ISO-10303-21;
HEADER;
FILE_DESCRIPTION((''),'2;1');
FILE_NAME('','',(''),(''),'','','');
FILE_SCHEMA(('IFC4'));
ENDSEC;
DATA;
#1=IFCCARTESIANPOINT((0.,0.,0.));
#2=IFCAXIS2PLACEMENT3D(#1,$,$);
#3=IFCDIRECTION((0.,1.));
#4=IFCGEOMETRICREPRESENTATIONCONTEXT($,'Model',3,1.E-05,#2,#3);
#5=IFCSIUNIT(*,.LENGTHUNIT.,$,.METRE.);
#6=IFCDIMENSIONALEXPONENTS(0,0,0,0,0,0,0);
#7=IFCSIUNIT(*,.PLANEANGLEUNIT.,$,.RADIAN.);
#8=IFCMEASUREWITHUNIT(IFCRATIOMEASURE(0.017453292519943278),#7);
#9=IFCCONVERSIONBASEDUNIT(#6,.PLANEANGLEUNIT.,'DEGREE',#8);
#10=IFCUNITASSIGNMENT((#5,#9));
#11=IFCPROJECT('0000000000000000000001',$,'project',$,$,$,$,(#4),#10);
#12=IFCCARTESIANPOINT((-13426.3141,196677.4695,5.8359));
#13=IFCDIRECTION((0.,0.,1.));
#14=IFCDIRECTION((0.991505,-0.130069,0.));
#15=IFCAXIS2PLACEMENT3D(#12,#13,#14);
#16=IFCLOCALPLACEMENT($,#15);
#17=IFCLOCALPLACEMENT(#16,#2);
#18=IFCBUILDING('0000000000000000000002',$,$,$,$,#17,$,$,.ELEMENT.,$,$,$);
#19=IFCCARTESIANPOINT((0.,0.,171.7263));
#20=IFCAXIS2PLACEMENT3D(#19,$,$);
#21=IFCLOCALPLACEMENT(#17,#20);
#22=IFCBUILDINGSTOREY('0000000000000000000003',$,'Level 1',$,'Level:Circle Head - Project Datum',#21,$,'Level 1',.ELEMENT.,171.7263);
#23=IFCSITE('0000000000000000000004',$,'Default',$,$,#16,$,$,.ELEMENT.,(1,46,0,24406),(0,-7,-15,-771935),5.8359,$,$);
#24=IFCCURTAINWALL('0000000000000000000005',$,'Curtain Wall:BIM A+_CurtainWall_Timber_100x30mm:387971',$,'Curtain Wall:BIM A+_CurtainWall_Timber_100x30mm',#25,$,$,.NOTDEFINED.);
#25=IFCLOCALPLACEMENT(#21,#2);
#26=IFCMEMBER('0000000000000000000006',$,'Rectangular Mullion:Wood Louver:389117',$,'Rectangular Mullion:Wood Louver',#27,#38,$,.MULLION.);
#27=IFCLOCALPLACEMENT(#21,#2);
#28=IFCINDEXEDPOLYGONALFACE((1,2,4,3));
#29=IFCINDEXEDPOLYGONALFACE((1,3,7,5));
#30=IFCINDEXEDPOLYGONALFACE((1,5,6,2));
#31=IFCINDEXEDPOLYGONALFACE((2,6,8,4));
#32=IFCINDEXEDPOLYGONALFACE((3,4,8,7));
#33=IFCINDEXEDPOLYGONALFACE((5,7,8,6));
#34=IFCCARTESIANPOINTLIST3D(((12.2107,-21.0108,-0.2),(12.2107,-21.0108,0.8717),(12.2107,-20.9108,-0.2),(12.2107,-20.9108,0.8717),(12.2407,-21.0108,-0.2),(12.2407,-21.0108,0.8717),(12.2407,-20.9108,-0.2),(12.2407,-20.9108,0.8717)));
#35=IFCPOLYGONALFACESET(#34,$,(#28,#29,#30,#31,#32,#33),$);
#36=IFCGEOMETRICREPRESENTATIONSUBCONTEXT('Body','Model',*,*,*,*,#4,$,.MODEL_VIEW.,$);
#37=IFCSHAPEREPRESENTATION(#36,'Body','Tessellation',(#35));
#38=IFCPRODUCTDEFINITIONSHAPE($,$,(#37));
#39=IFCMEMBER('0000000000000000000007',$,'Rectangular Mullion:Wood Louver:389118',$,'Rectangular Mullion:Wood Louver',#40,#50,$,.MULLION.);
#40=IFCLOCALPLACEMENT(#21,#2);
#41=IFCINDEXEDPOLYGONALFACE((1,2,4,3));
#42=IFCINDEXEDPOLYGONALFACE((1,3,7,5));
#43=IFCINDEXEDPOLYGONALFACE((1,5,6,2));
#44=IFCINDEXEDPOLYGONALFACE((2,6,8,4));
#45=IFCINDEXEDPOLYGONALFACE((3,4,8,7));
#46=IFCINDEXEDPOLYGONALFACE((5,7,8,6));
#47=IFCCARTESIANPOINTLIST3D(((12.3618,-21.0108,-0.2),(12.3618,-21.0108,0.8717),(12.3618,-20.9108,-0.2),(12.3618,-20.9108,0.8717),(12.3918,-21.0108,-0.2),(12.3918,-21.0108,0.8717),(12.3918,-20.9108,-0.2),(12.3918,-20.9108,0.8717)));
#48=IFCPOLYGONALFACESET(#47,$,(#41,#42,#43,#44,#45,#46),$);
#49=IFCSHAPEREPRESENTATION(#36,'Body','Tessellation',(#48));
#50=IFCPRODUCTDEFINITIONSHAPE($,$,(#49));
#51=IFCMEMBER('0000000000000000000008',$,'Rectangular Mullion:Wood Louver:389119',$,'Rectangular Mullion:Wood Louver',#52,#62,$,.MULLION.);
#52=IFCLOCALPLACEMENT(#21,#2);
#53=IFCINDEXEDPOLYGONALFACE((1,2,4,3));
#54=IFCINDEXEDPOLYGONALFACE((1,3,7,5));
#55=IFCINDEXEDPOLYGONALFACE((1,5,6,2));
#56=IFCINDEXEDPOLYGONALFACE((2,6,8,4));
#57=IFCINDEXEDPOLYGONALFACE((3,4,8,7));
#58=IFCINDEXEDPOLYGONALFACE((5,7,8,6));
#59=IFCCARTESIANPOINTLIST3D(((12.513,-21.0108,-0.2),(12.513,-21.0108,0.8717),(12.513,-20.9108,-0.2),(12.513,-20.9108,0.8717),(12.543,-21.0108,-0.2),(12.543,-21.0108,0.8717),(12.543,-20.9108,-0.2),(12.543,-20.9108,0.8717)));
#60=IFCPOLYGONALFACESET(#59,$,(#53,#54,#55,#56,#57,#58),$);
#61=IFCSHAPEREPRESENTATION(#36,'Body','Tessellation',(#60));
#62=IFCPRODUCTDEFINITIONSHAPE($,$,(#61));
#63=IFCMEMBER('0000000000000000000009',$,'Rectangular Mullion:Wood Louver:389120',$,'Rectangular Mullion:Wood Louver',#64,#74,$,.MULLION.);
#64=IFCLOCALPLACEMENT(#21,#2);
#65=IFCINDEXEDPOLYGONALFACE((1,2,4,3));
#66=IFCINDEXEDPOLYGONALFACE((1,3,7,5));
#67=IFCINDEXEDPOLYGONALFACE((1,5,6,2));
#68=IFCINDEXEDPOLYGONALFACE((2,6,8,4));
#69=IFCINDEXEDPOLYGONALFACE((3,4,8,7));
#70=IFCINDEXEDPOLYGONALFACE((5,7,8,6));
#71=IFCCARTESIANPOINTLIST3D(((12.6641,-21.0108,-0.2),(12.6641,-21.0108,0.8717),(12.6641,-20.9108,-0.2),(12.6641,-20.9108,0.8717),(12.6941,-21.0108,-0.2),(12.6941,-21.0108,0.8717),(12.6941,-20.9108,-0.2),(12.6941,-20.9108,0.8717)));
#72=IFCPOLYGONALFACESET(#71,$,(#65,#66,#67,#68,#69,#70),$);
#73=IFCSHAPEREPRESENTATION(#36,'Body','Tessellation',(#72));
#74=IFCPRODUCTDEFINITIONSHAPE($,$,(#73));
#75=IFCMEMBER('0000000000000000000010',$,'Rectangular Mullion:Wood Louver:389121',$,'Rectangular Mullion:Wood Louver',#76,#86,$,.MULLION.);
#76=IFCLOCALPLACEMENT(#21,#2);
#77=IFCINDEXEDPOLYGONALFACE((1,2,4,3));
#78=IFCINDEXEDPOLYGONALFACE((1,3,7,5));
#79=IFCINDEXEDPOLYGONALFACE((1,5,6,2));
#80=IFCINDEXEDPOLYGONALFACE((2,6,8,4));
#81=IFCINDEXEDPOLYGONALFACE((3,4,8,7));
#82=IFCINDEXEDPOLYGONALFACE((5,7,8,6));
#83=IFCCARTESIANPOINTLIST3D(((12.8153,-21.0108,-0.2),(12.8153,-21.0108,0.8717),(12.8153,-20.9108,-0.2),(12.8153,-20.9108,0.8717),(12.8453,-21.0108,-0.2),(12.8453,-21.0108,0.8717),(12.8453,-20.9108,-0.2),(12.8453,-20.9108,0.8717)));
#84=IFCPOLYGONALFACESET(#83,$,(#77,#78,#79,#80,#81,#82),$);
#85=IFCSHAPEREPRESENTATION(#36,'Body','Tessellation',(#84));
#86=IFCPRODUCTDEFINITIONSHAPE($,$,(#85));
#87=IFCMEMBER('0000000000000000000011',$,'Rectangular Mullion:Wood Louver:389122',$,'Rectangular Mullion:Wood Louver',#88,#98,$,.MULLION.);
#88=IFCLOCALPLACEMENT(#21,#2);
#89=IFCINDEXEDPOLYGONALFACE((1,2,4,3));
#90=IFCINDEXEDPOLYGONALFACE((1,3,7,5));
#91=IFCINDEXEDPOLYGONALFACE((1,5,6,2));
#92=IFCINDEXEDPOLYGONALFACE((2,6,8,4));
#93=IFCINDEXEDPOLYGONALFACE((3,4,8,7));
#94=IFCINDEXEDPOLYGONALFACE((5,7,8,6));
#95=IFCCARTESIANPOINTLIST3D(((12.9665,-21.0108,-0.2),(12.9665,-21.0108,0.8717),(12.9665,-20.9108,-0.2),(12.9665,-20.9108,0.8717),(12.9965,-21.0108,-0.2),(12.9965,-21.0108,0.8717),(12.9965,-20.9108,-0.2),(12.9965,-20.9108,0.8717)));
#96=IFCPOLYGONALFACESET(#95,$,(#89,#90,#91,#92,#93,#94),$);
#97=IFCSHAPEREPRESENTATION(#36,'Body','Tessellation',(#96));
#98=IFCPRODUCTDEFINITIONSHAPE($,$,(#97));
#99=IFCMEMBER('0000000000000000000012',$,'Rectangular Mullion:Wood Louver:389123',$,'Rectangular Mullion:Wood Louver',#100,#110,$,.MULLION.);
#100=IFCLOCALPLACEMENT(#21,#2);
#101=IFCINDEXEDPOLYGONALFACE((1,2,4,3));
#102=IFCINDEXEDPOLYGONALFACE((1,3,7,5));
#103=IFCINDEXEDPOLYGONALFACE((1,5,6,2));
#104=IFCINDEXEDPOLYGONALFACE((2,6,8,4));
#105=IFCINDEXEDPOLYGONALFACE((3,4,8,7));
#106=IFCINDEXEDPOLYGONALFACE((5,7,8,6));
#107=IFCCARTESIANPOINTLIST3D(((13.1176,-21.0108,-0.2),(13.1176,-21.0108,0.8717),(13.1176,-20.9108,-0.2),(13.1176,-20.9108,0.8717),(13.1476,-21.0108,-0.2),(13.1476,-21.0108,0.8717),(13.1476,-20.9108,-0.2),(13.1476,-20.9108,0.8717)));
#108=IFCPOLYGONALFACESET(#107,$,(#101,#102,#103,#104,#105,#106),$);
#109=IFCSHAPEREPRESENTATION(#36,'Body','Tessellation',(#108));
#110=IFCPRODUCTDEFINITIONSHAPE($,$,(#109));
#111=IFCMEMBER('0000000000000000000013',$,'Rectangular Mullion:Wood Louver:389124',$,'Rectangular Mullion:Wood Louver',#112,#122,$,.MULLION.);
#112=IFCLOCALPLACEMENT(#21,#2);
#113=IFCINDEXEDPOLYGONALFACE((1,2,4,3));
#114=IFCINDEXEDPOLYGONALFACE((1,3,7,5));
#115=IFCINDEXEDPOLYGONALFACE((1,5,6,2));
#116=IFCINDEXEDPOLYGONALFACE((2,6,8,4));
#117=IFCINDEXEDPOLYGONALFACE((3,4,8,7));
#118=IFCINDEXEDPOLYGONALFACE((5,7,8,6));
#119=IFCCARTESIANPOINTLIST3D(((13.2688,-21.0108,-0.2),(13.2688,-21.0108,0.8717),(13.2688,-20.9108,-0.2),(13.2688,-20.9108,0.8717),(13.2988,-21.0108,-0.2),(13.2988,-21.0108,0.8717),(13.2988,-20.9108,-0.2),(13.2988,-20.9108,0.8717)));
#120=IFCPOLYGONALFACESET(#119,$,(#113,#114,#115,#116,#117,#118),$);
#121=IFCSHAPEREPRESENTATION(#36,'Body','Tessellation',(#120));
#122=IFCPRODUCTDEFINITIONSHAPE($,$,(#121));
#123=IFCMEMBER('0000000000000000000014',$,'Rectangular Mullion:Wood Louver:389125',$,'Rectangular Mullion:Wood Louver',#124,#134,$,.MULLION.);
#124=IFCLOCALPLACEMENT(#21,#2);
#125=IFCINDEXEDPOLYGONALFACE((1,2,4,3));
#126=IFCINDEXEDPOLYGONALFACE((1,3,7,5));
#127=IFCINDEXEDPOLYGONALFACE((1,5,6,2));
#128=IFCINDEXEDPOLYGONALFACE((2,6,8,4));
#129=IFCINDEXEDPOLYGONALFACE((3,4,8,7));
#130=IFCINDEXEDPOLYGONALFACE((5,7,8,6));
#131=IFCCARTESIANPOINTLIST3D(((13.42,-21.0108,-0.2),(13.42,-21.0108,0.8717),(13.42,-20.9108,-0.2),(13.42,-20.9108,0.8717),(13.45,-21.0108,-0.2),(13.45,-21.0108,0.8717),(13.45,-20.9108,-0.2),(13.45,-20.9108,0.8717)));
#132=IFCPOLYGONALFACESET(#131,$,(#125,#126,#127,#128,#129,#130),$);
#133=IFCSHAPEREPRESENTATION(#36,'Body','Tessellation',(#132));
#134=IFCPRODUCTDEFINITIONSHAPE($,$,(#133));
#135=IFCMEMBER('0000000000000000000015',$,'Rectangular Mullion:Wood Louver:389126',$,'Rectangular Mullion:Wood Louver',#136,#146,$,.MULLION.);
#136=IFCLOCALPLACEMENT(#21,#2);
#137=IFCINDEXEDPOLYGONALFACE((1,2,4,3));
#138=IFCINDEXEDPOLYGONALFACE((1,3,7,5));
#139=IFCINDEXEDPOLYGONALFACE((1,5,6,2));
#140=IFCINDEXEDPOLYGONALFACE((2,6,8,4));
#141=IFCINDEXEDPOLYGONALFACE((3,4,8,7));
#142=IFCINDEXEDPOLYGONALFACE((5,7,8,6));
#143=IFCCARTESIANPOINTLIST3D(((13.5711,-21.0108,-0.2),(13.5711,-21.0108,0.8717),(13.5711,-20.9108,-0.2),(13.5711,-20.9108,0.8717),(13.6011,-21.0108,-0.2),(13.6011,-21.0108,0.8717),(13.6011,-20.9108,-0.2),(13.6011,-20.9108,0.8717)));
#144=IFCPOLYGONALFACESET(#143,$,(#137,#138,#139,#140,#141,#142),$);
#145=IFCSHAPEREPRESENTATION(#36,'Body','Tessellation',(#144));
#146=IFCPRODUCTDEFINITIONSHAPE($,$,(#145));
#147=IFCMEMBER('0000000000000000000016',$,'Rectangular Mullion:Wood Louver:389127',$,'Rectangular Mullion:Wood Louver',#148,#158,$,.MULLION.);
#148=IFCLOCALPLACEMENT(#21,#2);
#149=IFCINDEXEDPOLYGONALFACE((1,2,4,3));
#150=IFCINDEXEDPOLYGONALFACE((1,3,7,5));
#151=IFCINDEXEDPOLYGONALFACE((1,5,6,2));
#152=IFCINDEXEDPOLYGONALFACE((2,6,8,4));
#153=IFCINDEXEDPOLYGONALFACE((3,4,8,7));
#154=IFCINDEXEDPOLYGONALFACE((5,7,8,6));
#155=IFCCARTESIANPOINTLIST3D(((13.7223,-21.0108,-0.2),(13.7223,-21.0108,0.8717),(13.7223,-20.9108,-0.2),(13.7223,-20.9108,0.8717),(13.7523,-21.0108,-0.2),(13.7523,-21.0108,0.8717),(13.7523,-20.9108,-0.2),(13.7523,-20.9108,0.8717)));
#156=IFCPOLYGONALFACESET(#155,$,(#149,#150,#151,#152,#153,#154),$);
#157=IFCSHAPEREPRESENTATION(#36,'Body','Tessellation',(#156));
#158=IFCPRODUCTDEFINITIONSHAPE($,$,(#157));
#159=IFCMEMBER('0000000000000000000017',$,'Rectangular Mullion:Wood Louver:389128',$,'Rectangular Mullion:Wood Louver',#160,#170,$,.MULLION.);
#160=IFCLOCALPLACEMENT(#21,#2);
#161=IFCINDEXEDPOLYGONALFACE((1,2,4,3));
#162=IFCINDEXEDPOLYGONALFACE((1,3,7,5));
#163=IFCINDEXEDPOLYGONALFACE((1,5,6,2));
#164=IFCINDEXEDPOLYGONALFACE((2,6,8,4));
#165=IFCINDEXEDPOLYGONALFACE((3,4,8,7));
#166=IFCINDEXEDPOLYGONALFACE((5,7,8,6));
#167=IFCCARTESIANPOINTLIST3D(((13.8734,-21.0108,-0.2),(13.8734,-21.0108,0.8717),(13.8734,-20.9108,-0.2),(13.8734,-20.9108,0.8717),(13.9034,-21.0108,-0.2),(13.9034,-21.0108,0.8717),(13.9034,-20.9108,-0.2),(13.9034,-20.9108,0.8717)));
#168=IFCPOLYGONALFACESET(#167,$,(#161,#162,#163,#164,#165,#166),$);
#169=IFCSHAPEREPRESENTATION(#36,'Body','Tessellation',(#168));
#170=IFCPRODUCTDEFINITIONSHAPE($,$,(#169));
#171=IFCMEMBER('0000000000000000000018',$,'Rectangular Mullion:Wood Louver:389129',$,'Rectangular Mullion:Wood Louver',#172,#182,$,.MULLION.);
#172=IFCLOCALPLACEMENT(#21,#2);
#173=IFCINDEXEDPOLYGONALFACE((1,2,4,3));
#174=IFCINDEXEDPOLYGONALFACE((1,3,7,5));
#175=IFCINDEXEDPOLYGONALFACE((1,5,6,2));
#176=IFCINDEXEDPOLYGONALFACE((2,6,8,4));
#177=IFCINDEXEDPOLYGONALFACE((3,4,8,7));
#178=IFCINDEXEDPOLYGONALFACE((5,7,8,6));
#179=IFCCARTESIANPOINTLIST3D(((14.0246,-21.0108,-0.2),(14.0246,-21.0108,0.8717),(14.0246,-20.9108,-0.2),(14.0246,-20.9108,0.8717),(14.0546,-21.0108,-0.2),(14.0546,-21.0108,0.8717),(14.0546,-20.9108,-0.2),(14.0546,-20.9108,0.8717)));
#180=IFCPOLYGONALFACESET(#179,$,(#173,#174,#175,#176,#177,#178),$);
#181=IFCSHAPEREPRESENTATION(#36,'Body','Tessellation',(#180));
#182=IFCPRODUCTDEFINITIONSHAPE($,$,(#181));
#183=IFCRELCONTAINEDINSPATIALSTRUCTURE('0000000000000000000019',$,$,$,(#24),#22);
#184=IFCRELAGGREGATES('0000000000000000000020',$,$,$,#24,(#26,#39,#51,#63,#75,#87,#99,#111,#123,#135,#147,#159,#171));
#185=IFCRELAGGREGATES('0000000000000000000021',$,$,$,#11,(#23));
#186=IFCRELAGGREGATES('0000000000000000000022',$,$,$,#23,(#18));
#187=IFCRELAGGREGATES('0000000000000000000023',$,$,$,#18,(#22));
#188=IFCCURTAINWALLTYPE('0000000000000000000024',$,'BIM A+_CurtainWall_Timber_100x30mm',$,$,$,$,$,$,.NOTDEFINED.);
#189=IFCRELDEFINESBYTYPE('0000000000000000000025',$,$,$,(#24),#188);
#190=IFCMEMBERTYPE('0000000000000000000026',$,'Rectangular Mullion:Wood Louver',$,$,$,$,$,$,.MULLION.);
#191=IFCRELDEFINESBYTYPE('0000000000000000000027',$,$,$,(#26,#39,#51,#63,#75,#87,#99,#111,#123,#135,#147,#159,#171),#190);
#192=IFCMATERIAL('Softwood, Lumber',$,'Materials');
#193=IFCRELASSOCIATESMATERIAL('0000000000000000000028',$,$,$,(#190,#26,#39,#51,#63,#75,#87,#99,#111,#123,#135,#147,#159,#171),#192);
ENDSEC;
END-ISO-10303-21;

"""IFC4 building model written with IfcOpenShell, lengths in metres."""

from ifc_helpers import new_model, entity, si_unit, converted_unit, direction, frame, origin, place, context, subcontext, project, spatial, indexed_curve, outline, extrude, source, transform, mapped, material, type_object, type_shapes, element, aggregate, save


model = new_model("IFC4")

# Units and contexts
model_context = context("Model", 3, precision=1e-05, world=origin(), true_north=direction((0.0, 1.0)))
body_context = subcontext(model_context, "Body", "Model", "MODEL_VIEW")
ifc_project = project(units=[si_unit("LENGTHUNIT", "METRE"), converted_unit("PLANEANGLEUNIT", "DEGREE", entity("IfcRatioMeasure", 0.017453292519943278), si_unit("PLANEANGLEUNIT", "RADIAN"), dimensions=[0, 0, 0, 0, 0, 0, 0])], contexts=[model_context])

# Site, building, storey
site_placement = place(None, frame((-13426.3141, 196677.4695, 5.8359), z_axis=(0.0, 0.0, 1.0), x_axis=(0.991505, -0.130069, 0.0)))
site = spatial("IfcSite", under=ifc_project, at=site_placement, Name="Default", CompositionType="ELEMENT", RefLatitude=(1, 46, 0, 24406), RefLongitude=(0, -7, -15, -771935), RefElevation=5.8359)
building_placement = place(site_placement, origin())
building = spatial("IfcBuilding", under=site, at=building_placement, CompositionType="ELEMENT")
storey_placement = place(building_placement, frame((0.0, 0.0, 171.7263)))
storey = spatial("IfcBuildingStorey", under=building, at=storey_placement, Name="Level 1", ObjectType="Level:Circle Head - Project Datum", LongName="Level 1", CompositionType="ELEMENT", Elevation=171.7263)

# Curtain wall, members
curtain_wall_type = type_object("IfcCurtainWallType", Name="BIM A+_CurtainWall_Timber_100x30mm", PredefinedType="NOTDEFINED")
curtain_wall_placement = place(storey_placement, frame((0.0, 0.0, -171.7263)))
curtain_wall = element("IfcCurtainWall", 1, at=curtain_wall_placement, inside=storey, type_object=curtain_wall_type, Name="Curtain Wall:BIM A+_CurtainWall_Timber_100x30mm:387971", ObjectType="Curtain Wall:BIM A+_CurtainWall_Timber_100x30mm", PredefinedType="NOTDEFINED")
ifc_material_1 = material(Name="Softwood, Lumber", Category="Materials")
member_type_1 = type_object("IfcMemberType", Name="Rectangular Mullion:Wood Louver", PredefinedType="MULLION", material=ifc_material_1)
shared_shape_1 = source(origin(), body_context, "Body", "SweptSolid", [
    extrude(outline(indexed_curve([(-0.05, -0.015), (0.05, -0.015), (0.05, 0.015), (-0.05, 0.015), (-0.05, -0.015)], self_intersect=False)), frame((0.0, 0.035, -1.0717), z_axis=(0.0, 0.0, 1.0), x_axis=(0.0, -1.0, 0.0)), (0.0, 0.0, 1.0), 1.0717),
])
type_shapes(member_type_1, [shared_shape_1])
member_1_placement = place(curtain_wall_placement, frame((12.2257, -20.9258, 171.5263), z_axis=(0.0, 0.0, -1.0), x_axis=(1.0, 0.0, 0.0)))
member_1 = element("IfcMember", 2, at=member_1_placement, type_object=member_type_1, material=ifc_material_1, Name="Rectangular Mullion:Wood Louver:389117", ObjectType="Rectangular Mullion:Wood Louver", PredefinedType="MULLION", context=body_context, shape_type="MappedRepresentation", body=[
    mapped(shared_shape_1, transform((0.0, 0.0, 0.0), scale=1.0)),
])
member_2_placement = place(curtain_wall_placement, frame((12.3768, -20.9258, 171.5263), z_axis=(0.0, 0.0, -1.0), x_axis=(1.0, 0.0, 0.0)))
member_2 = element("IfcMember", 3, at=member_2_placement, type_object=member_type_1, material=ifc_material_1, Name="Rectangular Mullion:Wood Louver:389118", ObjectType="Rectangular Mullion:Wood Louver", PredefinedType="MULLION", context=body_context, shape_type="MappedRepresentation", body=[
    mapped(shared_shape_1, transform((0.0, 0.0, 0.0), scale=1.0)),
])
member_3_placement = place(curtain_wall_placement, frame((12.528, -20.9258, 171.5263), z_axis=(0.0, 0.0, -1.0), x_axis=(1.0, 0.0, 0.0)))
member_3 = element("IfcMember", 4, at=member_3_placement, type_object=member_type_1, material=ifc_material_1, Name="Rectangular Mullion:Wood Louver:389119", ObjectType="Rectangular Mullion:Wood Louver", PredefinedType="MULLION", context=body_context, shape_type="MappedRepresentation", body=[
    mapped(shared_shape_1, transform((0.0, 0.0, 0.0), scale=1.0)),
])
member_4_placement = place(curtain_wall_placement, frame((12.6791, -20.9258, 171.5263), z_axis=(0.0, 0.0, -1.0), x_axis=(1.0, 0.0, 0.0)))
member_4 = element("IfcMember", 5, at=member_4_placement, type_object=member_type_1, material=ifc_material_1, Name="Rectangular Mullion:Wood Louver:389120", ObjectType="Rectangular Mullion:Wood Louver", PredefinedType="MULLION", context=body_context, shape_type="MappedRepresentation", body=[
    mapped(shared_shape_1, transform((0.0, 0.0, 0.0), scale=1.0)),
])
member_5_placement = place(curtain_wall_placement, frame((12.8303, -20.9258, 171.5263), z_axis=(0.0, 0.0, -1.0), x_axis=(1.0, 0.0, 0.0)))
member_5 = element("IfcMember", 6, at=member_5_placement, type_object=member_type_1, material=ifc_material_1, Name="Rectangular Mullion:Wood Louver:389121", ObjectType="Rectangular Mullion:Wood Louver", PredefinedType="MULLION", context=body_context, shape_type="MappedRepresentation", body=[
    mapped(shared_shape_1, transform((0.0, 0.0, 0.0), scale=1.0)),
])
member_6_placement = place(curtain_wall_placement, frame((12.9815, -20.9258, 171.5263), z_axis=(0.0, 0.0, -1.0), x_axis=(1.0, 0.0, 0.0)))
member_6 = element("IfcMember", 7, at=member_6_placement, type_object=member_type_1, material=ifc_material_1, Name="Rectangular Mullion:Wood Louver:389122", ObjectType="Rectangular Mullion:Wood Louver", PredefinedType="MULLION", context=body_context, shape_type="MappedRepresentation", body=[
    mapped(shared_shape_1, transform((0.0, 0.0, 0.0), scale=1.0)),
])
member_7_placement = place(curtain_wall_placement, frame((13.1326, -20.9258, 171.5263), z_axis=(0.0, 0.0, -1.0), x_axis=(1.0, 0.0, 0.0)))
member_7 = element("IfcMember", 8, at=member_7_placement, type_object=member_type_1, material=ifc_material_1, Name="Rectangular Mullion:Wood Louver:389123", ObjectType="Rectangular Mullion:Wood Louver", PredefinedType="MULLION", context=body_context, shape_type="MappedRepresentation", body=[
    mapped(shared_shape_1, transform((0.0, 0.0, 0.0), scale=1.0)),
])
member_8_placement = place(curtain_wall_placement, frame((13.2838, -20.9258, 171.5263), z_axis=(0.0, 0.0, -1.0), x_axis=(1.0, 0.0, 0.0)))
member_8 = element("IfcMember", 9, at=member_8_placement, type_object=member_type_1, material=ifc_material_1, Name="Rectangular Mullion:Wood Louver:389124", ObjectType="Rectangular Mullion:Wood Louver", PredefinedType="MULLION", context=body_context, shape_type="MappedRepresentation", body=[
    mapped(shared_shape_1, transform((0.0, 0.0, 0.0), scale=1.0)),
])
member_9_placement = place(curtain_wall_placement, frame((13.435, -20.9258, 171.5263), z_axis=(0.0, 0.0, -1.0), x_axis=(1.0, 0.0, 0.0)))
member_9 = element("IfcMember", 10, at=member_9_placement, type_object=member_type_1, material=ifc_material_1, Name="Rectangular Mullion:Wood Louver:389125", ObjectType="Rectangular Mullion:Wood Louver", PredefinedType="MULLION", context=body_context, shape_type="MappedRepresentation", body=[
    mapped(shared_shape_1, transform((0.0, 0.0, 0.0), scale=1.0)),
])
member_10_placement = place(curtain_wall_placement, frame((13.5861, -20.9258, 171.5263), z_axis=(0.0, 0.0, -1.0), x_axis=(1.0, 0.0, 0.0)))
member_10 = element("IfcMember", 11, at=member_10_placement, type_object=member_type_1, material=ifc_material_1, Name="Rectangular Mullion:Wood Louver:389126", ObjectType="Rectangular Mullion:Wood Louver", PredefinedType="MULLION", context=body_context, shape_type="MappedRepresentation", body=[
    mapped(shared_shape_1, transform((0.0, 0.0, 0.0), scale=1.0)),
])
member_11_placement = place(curtain_wall_placement, frame((13.7373, -20.9258, 171.5263), z_axis=(0.0, 0.0, -1.0), x_axis=(1.0, 0.0, 0.0)))
member_11 = element("IfcMember", 12, at=member_11_placement, type_object=member_type_1, material=ifc_material_1, Name="Rectangular Mullion:Wood Louver:389127", ObjectType="Rectangular Mullion:Wood Louver", PredefinedType="MULLION", context=body_context, shape_type="MappedRepresentation", body=[
    mapped(shared_shape_1, transform((0.0, 0.0, 0.0), scale=1.0)),
])
member_12_placement = place(curtain_wall_placement, frame((13.8884, -20.9258, 171.5263), z_axis=(0.0, 0.0, -1.0), x_axis=(1.0, 0.0, 0.0)))
member_12 = element("IfcMember", 13, at=member_12_placement, type_object=member_type_1, material=ifc_material_1, Name="Rectangular Mullion:Wood Louver:389128", ObjectType="Rectangular Mullion:Wood Louver", PredefinedType="MULLION", context=body_context, shape_type="MappedRepresentation", body=[
    mapped(shared_shape_1, transform((0.0, 0.0, 0.0), scale=1.0)),
])
member_13_placement = place(curtain_wall_placement, frame((14.0396, -20.9258, 171.5263), z_axis=(0.0, 0.0, -1.0), x_axis=(1.0, 0.0, 0.0)))
member_13 = element("IfcMember", 14, at=member_13_placement, type_object=member_type_1, material=ifc_material_1, Name="Rectangular Mullion:Wood Louver:389129", ObjectType="Rectangular Mullion:Wood Louver", PredefinedType="MULLION", context=body_context, shape_type="MappedRepresentation", body=[
    mapped(shared_shape_1, transform((0.0, 0.0, 0.0), scale=1.0)),
])
aggregate(curtain_wall, [member_1, member_2, member_3, member_4, member_5, member_6, member_7, member_8, member_9, member_10, member_11, member_12, member_13])

save(model, "model.ifc")
